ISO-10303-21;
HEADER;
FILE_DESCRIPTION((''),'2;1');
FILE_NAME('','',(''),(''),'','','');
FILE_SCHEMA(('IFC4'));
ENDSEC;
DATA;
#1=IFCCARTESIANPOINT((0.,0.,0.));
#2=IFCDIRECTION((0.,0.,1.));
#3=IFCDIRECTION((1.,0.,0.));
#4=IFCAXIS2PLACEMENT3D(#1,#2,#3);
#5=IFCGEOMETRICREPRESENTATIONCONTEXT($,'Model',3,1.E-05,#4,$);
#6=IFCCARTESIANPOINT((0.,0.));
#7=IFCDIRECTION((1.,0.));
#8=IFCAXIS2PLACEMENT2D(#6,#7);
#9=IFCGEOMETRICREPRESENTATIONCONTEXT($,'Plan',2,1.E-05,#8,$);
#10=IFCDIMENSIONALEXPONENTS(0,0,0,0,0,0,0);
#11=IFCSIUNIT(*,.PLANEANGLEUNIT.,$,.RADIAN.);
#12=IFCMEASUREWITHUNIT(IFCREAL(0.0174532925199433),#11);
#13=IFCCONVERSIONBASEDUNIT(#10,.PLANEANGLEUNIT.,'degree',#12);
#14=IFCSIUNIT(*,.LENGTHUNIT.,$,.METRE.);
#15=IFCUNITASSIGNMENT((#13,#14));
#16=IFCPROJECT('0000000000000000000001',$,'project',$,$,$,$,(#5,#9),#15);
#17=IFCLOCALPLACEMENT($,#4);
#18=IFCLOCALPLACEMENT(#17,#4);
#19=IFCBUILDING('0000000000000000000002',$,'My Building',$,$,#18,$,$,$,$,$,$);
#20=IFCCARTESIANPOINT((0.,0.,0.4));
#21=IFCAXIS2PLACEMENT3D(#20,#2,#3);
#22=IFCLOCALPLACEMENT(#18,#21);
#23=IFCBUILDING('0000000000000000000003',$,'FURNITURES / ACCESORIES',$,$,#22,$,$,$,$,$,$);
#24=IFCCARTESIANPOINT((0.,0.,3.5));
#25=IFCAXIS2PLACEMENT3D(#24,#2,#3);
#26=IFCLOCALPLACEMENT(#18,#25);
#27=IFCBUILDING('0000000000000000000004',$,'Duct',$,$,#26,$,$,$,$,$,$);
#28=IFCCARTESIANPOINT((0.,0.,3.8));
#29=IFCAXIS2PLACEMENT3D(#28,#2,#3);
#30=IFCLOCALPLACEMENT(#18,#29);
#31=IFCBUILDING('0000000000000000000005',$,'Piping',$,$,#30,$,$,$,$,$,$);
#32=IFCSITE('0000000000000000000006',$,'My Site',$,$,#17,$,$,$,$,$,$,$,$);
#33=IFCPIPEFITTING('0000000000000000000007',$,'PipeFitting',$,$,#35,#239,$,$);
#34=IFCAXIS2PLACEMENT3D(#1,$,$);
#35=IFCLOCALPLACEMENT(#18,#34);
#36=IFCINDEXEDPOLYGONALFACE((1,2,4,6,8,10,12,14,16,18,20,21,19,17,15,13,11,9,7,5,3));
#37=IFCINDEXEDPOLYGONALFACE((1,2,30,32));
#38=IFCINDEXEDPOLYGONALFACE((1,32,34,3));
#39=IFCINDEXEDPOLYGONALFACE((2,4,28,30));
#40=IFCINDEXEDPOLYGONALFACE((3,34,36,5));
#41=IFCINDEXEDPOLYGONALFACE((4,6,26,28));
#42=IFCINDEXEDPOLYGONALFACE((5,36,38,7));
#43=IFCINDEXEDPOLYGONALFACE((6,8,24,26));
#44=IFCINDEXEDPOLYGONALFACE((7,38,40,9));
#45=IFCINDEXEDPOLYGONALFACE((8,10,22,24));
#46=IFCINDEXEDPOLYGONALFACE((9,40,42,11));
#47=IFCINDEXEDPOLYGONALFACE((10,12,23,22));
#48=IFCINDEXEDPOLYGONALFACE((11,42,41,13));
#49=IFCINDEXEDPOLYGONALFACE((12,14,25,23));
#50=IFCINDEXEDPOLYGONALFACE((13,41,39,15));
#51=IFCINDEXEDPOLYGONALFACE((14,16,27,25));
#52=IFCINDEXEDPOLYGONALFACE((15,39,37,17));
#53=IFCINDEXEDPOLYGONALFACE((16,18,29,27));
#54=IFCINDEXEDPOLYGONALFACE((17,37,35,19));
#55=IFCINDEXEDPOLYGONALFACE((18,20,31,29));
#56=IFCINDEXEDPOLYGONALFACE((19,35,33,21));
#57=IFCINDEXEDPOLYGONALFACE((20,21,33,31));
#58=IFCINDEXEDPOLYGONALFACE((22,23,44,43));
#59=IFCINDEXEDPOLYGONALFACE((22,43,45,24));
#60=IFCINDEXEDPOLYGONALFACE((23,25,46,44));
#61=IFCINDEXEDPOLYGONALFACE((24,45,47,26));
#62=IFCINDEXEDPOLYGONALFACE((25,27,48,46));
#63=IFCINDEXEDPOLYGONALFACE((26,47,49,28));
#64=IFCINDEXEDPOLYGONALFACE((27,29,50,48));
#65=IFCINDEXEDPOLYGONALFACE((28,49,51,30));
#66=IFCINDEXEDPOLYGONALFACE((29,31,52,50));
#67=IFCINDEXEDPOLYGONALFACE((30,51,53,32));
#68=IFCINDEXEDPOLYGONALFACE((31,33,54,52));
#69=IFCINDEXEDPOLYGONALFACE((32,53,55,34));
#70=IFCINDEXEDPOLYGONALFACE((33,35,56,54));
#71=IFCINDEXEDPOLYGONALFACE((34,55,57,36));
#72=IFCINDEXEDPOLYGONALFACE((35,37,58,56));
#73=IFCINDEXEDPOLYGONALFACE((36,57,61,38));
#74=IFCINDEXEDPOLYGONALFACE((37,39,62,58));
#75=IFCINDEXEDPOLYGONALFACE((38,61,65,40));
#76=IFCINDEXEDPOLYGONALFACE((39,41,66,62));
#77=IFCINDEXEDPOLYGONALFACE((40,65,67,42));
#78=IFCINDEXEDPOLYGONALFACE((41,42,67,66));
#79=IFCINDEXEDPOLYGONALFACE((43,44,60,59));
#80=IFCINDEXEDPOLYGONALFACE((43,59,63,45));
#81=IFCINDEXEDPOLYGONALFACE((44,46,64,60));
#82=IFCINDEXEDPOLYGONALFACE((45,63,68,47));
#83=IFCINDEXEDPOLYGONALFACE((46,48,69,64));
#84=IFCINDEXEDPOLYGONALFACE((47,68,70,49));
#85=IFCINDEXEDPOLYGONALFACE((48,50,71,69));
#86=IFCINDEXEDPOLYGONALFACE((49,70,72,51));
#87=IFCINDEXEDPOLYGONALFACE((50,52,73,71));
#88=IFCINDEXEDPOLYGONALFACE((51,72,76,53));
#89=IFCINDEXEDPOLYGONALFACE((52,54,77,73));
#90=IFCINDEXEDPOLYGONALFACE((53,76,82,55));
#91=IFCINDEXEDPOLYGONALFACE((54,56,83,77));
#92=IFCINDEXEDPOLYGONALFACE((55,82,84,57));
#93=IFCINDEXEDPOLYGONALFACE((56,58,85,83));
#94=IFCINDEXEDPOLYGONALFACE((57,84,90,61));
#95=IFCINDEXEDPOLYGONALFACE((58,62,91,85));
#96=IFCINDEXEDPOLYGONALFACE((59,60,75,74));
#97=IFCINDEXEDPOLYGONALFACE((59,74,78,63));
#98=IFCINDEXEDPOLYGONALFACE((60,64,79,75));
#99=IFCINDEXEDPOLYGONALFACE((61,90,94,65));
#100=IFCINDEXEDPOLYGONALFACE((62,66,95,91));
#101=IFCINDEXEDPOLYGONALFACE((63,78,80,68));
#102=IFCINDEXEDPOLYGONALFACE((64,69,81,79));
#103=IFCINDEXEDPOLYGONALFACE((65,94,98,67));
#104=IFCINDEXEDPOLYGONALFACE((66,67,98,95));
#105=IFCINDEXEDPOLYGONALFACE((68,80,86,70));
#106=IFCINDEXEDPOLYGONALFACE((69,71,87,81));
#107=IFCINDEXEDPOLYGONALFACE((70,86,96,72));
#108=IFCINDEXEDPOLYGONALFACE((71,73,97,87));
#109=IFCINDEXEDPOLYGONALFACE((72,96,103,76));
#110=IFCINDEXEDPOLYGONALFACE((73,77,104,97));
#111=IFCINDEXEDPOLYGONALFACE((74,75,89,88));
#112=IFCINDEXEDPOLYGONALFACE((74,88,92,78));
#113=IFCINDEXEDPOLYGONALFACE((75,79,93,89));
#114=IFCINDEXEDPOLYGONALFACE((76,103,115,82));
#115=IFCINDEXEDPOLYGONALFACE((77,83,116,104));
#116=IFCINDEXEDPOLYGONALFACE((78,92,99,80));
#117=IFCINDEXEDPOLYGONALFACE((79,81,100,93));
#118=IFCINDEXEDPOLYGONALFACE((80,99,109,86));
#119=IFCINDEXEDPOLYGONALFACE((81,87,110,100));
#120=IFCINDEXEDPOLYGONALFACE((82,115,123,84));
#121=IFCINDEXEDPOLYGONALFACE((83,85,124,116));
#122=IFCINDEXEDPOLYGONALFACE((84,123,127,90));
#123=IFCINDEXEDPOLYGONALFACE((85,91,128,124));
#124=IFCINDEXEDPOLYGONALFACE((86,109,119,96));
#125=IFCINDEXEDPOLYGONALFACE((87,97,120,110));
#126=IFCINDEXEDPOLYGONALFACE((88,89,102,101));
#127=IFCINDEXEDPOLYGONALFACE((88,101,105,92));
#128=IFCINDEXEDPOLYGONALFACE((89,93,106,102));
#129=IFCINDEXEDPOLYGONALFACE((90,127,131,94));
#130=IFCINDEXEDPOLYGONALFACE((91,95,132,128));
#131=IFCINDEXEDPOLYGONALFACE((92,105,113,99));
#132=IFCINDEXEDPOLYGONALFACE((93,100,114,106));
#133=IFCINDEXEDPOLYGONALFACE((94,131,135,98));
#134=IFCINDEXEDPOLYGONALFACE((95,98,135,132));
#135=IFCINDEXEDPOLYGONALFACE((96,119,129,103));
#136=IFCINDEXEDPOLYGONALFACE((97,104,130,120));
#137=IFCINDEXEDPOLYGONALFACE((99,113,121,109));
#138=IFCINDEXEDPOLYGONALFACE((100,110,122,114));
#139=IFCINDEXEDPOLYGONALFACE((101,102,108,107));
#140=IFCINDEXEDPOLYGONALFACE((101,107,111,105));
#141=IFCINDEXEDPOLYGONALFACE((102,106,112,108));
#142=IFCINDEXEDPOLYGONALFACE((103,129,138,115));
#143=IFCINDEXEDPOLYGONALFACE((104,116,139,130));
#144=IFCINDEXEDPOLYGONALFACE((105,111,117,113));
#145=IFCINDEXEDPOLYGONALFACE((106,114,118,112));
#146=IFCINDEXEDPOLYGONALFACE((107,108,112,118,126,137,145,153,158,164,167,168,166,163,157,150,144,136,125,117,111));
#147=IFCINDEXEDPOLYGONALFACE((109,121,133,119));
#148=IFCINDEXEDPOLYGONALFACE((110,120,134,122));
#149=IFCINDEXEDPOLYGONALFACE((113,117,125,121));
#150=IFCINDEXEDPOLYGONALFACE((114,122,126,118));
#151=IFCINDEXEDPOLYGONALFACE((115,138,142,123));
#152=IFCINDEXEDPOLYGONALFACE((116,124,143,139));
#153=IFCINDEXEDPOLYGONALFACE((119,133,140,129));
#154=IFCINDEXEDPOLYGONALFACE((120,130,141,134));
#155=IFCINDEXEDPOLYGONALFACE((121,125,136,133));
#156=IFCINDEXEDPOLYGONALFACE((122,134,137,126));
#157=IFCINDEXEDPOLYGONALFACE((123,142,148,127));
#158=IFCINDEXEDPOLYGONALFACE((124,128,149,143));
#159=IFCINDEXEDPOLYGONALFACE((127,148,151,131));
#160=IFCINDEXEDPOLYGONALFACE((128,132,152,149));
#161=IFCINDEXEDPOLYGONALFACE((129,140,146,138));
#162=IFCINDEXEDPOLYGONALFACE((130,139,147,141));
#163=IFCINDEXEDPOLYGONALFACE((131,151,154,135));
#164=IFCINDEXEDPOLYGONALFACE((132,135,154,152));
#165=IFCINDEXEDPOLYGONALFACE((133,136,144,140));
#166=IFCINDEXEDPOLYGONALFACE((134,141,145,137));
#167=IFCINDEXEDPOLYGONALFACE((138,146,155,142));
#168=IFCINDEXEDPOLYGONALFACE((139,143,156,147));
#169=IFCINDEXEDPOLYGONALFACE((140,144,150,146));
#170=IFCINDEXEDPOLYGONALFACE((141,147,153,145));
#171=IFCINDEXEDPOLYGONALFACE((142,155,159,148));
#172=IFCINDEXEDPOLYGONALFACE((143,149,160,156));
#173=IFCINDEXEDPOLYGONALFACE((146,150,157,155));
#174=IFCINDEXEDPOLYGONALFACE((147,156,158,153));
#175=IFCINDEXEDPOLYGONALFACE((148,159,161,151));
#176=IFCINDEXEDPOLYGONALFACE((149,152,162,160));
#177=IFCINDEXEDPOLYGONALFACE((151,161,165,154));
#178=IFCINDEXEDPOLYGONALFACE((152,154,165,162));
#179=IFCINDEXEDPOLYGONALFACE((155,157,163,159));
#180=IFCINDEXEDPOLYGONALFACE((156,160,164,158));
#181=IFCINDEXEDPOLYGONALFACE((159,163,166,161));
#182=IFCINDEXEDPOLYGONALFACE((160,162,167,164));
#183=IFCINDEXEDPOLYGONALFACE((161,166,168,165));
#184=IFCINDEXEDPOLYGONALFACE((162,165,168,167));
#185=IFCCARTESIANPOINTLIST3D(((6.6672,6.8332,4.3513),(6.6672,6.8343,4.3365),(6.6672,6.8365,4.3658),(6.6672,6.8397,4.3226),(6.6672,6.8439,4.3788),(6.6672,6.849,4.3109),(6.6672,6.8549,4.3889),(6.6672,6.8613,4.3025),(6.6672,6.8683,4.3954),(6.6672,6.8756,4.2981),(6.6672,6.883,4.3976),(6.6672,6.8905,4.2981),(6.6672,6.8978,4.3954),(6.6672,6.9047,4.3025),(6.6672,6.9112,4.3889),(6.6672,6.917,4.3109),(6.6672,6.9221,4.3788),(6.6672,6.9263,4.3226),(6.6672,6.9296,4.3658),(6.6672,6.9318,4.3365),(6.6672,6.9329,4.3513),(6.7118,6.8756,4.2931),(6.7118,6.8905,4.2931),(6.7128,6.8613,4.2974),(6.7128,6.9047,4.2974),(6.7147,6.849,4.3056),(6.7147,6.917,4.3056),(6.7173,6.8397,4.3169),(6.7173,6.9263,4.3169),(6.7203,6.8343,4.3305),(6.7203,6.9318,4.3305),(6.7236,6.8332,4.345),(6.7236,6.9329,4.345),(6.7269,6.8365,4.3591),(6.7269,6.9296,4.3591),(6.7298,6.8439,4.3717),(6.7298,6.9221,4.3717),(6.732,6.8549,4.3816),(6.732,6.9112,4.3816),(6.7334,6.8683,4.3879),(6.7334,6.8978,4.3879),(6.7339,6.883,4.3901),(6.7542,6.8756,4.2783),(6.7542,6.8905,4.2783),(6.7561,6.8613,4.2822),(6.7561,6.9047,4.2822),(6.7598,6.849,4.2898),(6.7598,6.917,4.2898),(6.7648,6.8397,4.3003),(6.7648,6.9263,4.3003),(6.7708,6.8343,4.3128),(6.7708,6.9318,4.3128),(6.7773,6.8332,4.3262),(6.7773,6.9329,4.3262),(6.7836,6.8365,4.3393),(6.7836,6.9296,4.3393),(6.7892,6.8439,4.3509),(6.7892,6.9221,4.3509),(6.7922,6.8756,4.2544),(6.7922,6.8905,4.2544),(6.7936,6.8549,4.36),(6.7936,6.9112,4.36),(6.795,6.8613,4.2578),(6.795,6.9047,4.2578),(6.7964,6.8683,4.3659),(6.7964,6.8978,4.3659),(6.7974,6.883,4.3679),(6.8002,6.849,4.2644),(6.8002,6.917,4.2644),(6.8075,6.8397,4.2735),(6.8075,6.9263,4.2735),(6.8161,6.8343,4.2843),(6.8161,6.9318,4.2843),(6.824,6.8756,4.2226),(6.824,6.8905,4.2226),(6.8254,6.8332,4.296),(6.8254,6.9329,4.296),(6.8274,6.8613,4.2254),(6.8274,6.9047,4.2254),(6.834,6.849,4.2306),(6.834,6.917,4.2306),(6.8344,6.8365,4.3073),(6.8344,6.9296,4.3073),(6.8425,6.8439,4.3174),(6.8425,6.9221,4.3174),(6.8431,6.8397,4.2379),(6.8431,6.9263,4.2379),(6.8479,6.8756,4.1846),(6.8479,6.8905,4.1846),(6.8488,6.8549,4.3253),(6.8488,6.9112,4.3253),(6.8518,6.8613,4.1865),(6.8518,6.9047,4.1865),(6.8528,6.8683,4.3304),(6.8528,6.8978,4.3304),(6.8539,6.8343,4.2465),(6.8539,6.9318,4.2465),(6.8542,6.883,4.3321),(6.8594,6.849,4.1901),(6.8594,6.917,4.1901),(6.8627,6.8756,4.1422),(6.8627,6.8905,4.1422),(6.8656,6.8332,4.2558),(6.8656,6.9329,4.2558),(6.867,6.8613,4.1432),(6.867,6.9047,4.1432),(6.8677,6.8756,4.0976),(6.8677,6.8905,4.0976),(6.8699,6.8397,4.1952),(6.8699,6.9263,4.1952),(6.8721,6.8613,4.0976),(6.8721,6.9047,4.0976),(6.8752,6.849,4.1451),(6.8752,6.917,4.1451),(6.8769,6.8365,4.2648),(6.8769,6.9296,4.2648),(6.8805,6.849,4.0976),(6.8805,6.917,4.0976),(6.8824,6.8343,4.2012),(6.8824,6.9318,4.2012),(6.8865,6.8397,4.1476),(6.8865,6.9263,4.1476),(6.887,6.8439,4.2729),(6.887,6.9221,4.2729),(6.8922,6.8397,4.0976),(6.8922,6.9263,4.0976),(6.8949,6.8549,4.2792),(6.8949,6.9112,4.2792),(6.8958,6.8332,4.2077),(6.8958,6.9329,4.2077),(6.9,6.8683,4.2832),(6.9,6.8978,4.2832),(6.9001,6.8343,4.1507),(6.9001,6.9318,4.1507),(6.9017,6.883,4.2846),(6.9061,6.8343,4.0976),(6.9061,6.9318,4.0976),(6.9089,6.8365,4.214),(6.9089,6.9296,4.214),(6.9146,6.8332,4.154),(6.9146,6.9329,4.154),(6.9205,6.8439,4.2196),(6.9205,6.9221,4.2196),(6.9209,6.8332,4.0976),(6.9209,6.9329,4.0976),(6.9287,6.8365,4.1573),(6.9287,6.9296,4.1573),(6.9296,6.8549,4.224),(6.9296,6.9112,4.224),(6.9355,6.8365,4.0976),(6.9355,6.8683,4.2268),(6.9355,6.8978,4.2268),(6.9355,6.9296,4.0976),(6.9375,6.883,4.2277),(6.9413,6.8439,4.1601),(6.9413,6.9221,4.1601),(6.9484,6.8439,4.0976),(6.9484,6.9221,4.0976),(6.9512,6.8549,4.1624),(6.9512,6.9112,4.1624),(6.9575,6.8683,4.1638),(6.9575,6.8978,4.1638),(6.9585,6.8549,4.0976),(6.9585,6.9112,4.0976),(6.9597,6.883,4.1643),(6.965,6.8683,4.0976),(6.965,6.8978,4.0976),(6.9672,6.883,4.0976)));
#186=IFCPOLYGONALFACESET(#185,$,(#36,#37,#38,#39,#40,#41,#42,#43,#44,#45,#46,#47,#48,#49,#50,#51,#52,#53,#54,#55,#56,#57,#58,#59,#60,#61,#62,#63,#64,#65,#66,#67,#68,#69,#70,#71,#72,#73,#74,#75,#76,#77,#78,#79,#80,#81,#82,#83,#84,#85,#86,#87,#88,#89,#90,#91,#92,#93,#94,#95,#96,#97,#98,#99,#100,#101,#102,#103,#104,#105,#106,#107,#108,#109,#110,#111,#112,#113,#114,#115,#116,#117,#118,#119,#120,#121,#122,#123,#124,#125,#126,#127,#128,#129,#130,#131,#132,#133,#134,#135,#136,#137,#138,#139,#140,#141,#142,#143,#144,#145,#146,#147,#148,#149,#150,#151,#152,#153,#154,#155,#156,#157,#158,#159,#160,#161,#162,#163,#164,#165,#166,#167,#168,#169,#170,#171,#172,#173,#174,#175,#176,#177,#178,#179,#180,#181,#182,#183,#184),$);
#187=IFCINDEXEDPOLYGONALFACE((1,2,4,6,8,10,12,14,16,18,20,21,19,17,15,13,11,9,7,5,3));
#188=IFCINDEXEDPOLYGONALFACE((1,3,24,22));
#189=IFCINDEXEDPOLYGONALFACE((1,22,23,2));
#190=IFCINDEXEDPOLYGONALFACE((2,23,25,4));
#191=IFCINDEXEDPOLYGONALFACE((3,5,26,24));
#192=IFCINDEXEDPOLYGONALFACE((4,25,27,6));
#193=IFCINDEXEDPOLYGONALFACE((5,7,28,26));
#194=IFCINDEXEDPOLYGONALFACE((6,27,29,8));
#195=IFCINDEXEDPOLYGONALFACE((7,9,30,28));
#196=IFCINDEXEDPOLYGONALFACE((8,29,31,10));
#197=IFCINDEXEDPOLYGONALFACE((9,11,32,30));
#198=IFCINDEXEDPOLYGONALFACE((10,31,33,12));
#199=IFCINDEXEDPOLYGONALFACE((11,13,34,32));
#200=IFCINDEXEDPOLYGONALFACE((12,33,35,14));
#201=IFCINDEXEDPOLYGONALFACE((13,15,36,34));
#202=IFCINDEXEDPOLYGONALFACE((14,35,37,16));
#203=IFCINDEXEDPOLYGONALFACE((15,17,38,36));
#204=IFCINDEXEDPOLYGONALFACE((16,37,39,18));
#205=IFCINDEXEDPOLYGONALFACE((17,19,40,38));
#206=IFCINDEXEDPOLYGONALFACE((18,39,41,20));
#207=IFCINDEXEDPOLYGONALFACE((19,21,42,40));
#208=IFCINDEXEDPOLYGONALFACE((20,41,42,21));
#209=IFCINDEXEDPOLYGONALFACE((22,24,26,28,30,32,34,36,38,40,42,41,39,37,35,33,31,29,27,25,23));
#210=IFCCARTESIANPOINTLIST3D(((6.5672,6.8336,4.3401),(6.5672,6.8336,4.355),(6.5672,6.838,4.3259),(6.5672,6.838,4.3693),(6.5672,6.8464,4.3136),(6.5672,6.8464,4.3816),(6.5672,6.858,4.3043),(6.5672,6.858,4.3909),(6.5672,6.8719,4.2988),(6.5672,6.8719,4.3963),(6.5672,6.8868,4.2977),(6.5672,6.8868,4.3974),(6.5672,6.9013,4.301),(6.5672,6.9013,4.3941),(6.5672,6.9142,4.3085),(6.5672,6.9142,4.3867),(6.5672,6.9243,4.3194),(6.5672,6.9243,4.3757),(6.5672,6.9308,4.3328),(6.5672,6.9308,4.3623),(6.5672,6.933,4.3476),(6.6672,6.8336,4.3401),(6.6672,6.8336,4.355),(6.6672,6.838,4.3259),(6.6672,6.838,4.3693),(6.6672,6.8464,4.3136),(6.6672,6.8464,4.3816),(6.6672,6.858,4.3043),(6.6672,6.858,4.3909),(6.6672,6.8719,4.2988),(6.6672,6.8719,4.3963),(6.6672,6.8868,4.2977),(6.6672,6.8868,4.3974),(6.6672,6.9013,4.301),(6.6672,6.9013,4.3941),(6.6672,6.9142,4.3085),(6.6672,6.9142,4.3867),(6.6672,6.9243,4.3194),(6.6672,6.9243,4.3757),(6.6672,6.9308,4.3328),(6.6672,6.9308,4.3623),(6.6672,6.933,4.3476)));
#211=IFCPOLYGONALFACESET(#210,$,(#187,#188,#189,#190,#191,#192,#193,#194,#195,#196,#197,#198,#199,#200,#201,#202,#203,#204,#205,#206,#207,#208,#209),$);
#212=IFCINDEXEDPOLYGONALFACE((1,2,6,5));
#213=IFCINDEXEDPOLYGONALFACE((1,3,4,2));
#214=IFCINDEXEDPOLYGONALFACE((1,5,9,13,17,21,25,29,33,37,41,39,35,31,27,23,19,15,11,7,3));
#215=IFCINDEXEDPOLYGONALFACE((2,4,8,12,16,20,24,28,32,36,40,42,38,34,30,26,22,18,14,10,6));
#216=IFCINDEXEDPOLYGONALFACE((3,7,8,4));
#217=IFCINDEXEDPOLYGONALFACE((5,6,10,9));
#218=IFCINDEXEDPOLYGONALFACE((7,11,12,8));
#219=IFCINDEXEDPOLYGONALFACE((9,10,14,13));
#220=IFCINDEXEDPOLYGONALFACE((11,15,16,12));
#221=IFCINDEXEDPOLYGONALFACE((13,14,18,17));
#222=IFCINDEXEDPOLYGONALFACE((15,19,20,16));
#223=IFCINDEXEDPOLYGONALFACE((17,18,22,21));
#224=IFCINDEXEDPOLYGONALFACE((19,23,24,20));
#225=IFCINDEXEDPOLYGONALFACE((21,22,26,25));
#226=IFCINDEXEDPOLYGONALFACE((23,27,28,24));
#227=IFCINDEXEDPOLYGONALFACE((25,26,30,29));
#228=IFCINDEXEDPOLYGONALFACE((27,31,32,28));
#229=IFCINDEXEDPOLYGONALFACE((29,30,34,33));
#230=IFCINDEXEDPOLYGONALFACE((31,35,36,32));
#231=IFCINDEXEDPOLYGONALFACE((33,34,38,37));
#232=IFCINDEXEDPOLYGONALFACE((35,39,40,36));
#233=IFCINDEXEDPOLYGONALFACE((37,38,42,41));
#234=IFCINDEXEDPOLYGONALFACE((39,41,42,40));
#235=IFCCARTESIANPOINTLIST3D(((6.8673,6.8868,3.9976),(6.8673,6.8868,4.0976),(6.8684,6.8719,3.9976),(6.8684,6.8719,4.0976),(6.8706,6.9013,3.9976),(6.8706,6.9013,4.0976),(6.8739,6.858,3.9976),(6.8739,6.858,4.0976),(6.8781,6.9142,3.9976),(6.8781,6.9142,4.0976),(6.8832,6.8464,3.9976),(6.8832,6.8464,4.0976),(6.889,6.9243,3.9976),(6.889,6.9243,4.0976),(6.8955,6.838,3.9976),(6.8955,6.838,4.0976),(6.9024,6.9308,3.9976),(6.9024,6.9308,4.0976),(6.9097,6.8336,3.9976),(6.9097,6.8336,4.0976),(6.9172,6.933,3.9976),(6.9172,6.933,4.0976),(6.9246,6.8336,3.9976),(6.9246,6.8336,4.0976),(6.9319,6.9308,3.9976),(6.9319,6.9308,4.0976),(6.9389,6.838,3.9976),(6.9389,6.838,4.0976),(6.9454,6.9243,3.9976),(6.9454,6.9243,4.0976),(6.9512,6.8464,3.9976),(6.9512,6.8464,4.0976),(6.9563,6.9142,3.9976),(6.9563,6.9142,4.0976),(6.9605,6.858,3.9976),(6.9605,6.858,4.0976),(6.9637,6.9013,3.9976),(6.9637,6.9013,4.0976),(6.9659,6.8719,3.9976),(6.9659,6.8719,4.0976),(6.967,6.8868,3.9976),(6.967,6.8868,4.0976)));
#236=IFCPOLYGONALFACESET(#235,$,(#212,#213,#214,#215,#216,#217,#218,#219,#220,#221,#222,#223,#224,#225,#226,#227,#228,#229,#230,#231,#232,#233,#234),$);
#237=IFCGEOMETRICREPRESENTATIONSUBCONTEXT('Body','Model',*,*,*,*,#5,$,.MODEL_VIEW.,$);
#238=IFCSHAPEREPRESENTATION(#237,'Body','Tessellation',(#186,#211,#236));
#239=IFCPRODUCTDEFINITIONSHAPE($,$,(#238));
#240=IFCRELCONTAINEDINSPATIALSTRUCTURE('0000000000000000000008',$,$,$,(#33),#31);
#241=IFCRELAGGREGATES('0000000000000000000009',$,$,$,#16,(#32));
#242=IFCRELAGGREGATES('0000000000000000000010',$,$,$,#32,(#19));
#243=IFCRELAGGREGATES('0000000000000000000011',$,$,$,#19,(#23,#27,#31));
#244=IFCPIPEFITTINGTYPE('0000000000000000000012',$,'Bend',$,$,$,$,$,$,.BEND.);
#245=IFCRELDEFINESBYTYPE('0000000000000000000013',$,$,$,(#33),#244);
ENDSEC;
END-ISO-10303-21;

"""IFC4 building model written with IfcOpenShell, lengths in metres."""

from ifc_helpers import new_model, entity, si_unit, converted_unit, frame, origin_with_axes, origin_2d_with_axis, place, context, subcontext, project, spatial, circle, extrude, source, transform, mapped, type_object, type_shapes, element, save


model = new_model("IFC4")

# Units and contexts
model_context = context("Model", 3, precision=1e-05, world=origin_with_axes())
plan_context = context("Plan", 2, precision=1e-05, world=origin_2d_with_axis())
body_context_1 = subcontext(model_context, "Body", "Model", "MODEL_VIEW")
ifc_project = project(units=[converted_unit("PLANEANGLEUNIT", "degree", entity("IfcReal", 0.0174532925199433), si_unit("PLANEANGLEUNIT", "RADIAN"), dimensions=[0, 0, 0, 0, 0, 0, 0]), si_unit("LENGTHUNIT", "METRE")], contexts=[model_context, plan_context])

# Site, building
site_placement = place(None, origin_with_axes())
site = spatial("IfcSite", under=ifc_project, at=site_placement, Name="My Site")
building_1_placement = place(site_placement, origin_with_axes())
building_1 = spatial("IfcBuilding", under=site, at=building_1_placement, Name="My Building")

# Shared definitions
building_2_placement = place(building_1_placement, frame((0.0, 0.0, 0.4), z_axis=(0.0, 0.0, 1.0), x_axis=(1.0, 0.0, 0.0)))
building_2 = spatial("IfcBuilding", under=building_1, at=building_2_placement, Name="FURNITURES / ACCESORIES")

# Shared definitions
building_3_placement = place(building_1_placement, frame((0.0, 0.0, 3.5), z_axis=(0.0, 0.0, 1.0), x_axis=(1.0, 0.0, 0.0)))
building_3 = spatial("IfcBuilding", under=building_1, at=building_3_placement, Name="Duct")

# Shared definitions
building_4_placement = place(building_1_placement, frame((0.0, 0.0, 3.8), z_axis=(0.0, 0.0, 1.0), x_axis=(1.0, 0.0, 0.0)))
building_4 = spatial("IfcBuilding", under=building_1, at=building_4_placement, Name="Piping")

# Pipe fitting
pipe_fitting_type = type_object("IfcPipeFittingType", Name="Bend", PredefinedType="BEND")
shared_shape_1 = source(origin_with_axes(), body_context_1, "Body", "SolidModel", [
    entity("IfcSweptDiskSolid", entity("IfcIndexedPolyCurve", entity("IfcCartesianPointList3D", [[0.0, 0.0, 0.1], [0.0, -0.0732, 0.2768], [0.0, -0.25, 0.35]]), [entity("IfcArcIndex", [1, 2, 3])]), 0.05),
    extrude(circle(Radius=0.05), origin_with_axes(), (0.0, 0.0, 1.0), 0.1),
    extrude(circle(Radius=0.05), frame((0.0, -0.25, 0.35), z_axis=(0.0, -1.0, -0.000001), x_axis=(1.0, 0.0, 0.0)), (0.0, 0.0, 1.0), 0.1),
])
type_shapes(pipe_fitting_type, [shared_shape_1])
for number, where, z_axis, x_axis, name in (
    (1, (6.5672, 6.883, 0.5476), (1.0, -0.000001, 0.000001), (0.000001, 1.0, 0.0), "PipeFitting"),
):
    element("IfcPipeFitting", number, at=place(building_4_placement, frame(where, z_axis=z_axis, x_axis=x_axis)), inside=building_4, type_object=pipe_fitting_type, Name=name, context=body_context_1, shape_type="MappedRepresentation", body=[
        mapped(shared_shape_1, transform((0.0, 0.0, 0.0), x_axis=(1.0, 0.0, 0.0), y_axis=(0.0, 1.0, 0.0), z_axis=(0.0, 0.0, 1.0), scale=1.0)),
    ])

save(model, "model.ifc")
